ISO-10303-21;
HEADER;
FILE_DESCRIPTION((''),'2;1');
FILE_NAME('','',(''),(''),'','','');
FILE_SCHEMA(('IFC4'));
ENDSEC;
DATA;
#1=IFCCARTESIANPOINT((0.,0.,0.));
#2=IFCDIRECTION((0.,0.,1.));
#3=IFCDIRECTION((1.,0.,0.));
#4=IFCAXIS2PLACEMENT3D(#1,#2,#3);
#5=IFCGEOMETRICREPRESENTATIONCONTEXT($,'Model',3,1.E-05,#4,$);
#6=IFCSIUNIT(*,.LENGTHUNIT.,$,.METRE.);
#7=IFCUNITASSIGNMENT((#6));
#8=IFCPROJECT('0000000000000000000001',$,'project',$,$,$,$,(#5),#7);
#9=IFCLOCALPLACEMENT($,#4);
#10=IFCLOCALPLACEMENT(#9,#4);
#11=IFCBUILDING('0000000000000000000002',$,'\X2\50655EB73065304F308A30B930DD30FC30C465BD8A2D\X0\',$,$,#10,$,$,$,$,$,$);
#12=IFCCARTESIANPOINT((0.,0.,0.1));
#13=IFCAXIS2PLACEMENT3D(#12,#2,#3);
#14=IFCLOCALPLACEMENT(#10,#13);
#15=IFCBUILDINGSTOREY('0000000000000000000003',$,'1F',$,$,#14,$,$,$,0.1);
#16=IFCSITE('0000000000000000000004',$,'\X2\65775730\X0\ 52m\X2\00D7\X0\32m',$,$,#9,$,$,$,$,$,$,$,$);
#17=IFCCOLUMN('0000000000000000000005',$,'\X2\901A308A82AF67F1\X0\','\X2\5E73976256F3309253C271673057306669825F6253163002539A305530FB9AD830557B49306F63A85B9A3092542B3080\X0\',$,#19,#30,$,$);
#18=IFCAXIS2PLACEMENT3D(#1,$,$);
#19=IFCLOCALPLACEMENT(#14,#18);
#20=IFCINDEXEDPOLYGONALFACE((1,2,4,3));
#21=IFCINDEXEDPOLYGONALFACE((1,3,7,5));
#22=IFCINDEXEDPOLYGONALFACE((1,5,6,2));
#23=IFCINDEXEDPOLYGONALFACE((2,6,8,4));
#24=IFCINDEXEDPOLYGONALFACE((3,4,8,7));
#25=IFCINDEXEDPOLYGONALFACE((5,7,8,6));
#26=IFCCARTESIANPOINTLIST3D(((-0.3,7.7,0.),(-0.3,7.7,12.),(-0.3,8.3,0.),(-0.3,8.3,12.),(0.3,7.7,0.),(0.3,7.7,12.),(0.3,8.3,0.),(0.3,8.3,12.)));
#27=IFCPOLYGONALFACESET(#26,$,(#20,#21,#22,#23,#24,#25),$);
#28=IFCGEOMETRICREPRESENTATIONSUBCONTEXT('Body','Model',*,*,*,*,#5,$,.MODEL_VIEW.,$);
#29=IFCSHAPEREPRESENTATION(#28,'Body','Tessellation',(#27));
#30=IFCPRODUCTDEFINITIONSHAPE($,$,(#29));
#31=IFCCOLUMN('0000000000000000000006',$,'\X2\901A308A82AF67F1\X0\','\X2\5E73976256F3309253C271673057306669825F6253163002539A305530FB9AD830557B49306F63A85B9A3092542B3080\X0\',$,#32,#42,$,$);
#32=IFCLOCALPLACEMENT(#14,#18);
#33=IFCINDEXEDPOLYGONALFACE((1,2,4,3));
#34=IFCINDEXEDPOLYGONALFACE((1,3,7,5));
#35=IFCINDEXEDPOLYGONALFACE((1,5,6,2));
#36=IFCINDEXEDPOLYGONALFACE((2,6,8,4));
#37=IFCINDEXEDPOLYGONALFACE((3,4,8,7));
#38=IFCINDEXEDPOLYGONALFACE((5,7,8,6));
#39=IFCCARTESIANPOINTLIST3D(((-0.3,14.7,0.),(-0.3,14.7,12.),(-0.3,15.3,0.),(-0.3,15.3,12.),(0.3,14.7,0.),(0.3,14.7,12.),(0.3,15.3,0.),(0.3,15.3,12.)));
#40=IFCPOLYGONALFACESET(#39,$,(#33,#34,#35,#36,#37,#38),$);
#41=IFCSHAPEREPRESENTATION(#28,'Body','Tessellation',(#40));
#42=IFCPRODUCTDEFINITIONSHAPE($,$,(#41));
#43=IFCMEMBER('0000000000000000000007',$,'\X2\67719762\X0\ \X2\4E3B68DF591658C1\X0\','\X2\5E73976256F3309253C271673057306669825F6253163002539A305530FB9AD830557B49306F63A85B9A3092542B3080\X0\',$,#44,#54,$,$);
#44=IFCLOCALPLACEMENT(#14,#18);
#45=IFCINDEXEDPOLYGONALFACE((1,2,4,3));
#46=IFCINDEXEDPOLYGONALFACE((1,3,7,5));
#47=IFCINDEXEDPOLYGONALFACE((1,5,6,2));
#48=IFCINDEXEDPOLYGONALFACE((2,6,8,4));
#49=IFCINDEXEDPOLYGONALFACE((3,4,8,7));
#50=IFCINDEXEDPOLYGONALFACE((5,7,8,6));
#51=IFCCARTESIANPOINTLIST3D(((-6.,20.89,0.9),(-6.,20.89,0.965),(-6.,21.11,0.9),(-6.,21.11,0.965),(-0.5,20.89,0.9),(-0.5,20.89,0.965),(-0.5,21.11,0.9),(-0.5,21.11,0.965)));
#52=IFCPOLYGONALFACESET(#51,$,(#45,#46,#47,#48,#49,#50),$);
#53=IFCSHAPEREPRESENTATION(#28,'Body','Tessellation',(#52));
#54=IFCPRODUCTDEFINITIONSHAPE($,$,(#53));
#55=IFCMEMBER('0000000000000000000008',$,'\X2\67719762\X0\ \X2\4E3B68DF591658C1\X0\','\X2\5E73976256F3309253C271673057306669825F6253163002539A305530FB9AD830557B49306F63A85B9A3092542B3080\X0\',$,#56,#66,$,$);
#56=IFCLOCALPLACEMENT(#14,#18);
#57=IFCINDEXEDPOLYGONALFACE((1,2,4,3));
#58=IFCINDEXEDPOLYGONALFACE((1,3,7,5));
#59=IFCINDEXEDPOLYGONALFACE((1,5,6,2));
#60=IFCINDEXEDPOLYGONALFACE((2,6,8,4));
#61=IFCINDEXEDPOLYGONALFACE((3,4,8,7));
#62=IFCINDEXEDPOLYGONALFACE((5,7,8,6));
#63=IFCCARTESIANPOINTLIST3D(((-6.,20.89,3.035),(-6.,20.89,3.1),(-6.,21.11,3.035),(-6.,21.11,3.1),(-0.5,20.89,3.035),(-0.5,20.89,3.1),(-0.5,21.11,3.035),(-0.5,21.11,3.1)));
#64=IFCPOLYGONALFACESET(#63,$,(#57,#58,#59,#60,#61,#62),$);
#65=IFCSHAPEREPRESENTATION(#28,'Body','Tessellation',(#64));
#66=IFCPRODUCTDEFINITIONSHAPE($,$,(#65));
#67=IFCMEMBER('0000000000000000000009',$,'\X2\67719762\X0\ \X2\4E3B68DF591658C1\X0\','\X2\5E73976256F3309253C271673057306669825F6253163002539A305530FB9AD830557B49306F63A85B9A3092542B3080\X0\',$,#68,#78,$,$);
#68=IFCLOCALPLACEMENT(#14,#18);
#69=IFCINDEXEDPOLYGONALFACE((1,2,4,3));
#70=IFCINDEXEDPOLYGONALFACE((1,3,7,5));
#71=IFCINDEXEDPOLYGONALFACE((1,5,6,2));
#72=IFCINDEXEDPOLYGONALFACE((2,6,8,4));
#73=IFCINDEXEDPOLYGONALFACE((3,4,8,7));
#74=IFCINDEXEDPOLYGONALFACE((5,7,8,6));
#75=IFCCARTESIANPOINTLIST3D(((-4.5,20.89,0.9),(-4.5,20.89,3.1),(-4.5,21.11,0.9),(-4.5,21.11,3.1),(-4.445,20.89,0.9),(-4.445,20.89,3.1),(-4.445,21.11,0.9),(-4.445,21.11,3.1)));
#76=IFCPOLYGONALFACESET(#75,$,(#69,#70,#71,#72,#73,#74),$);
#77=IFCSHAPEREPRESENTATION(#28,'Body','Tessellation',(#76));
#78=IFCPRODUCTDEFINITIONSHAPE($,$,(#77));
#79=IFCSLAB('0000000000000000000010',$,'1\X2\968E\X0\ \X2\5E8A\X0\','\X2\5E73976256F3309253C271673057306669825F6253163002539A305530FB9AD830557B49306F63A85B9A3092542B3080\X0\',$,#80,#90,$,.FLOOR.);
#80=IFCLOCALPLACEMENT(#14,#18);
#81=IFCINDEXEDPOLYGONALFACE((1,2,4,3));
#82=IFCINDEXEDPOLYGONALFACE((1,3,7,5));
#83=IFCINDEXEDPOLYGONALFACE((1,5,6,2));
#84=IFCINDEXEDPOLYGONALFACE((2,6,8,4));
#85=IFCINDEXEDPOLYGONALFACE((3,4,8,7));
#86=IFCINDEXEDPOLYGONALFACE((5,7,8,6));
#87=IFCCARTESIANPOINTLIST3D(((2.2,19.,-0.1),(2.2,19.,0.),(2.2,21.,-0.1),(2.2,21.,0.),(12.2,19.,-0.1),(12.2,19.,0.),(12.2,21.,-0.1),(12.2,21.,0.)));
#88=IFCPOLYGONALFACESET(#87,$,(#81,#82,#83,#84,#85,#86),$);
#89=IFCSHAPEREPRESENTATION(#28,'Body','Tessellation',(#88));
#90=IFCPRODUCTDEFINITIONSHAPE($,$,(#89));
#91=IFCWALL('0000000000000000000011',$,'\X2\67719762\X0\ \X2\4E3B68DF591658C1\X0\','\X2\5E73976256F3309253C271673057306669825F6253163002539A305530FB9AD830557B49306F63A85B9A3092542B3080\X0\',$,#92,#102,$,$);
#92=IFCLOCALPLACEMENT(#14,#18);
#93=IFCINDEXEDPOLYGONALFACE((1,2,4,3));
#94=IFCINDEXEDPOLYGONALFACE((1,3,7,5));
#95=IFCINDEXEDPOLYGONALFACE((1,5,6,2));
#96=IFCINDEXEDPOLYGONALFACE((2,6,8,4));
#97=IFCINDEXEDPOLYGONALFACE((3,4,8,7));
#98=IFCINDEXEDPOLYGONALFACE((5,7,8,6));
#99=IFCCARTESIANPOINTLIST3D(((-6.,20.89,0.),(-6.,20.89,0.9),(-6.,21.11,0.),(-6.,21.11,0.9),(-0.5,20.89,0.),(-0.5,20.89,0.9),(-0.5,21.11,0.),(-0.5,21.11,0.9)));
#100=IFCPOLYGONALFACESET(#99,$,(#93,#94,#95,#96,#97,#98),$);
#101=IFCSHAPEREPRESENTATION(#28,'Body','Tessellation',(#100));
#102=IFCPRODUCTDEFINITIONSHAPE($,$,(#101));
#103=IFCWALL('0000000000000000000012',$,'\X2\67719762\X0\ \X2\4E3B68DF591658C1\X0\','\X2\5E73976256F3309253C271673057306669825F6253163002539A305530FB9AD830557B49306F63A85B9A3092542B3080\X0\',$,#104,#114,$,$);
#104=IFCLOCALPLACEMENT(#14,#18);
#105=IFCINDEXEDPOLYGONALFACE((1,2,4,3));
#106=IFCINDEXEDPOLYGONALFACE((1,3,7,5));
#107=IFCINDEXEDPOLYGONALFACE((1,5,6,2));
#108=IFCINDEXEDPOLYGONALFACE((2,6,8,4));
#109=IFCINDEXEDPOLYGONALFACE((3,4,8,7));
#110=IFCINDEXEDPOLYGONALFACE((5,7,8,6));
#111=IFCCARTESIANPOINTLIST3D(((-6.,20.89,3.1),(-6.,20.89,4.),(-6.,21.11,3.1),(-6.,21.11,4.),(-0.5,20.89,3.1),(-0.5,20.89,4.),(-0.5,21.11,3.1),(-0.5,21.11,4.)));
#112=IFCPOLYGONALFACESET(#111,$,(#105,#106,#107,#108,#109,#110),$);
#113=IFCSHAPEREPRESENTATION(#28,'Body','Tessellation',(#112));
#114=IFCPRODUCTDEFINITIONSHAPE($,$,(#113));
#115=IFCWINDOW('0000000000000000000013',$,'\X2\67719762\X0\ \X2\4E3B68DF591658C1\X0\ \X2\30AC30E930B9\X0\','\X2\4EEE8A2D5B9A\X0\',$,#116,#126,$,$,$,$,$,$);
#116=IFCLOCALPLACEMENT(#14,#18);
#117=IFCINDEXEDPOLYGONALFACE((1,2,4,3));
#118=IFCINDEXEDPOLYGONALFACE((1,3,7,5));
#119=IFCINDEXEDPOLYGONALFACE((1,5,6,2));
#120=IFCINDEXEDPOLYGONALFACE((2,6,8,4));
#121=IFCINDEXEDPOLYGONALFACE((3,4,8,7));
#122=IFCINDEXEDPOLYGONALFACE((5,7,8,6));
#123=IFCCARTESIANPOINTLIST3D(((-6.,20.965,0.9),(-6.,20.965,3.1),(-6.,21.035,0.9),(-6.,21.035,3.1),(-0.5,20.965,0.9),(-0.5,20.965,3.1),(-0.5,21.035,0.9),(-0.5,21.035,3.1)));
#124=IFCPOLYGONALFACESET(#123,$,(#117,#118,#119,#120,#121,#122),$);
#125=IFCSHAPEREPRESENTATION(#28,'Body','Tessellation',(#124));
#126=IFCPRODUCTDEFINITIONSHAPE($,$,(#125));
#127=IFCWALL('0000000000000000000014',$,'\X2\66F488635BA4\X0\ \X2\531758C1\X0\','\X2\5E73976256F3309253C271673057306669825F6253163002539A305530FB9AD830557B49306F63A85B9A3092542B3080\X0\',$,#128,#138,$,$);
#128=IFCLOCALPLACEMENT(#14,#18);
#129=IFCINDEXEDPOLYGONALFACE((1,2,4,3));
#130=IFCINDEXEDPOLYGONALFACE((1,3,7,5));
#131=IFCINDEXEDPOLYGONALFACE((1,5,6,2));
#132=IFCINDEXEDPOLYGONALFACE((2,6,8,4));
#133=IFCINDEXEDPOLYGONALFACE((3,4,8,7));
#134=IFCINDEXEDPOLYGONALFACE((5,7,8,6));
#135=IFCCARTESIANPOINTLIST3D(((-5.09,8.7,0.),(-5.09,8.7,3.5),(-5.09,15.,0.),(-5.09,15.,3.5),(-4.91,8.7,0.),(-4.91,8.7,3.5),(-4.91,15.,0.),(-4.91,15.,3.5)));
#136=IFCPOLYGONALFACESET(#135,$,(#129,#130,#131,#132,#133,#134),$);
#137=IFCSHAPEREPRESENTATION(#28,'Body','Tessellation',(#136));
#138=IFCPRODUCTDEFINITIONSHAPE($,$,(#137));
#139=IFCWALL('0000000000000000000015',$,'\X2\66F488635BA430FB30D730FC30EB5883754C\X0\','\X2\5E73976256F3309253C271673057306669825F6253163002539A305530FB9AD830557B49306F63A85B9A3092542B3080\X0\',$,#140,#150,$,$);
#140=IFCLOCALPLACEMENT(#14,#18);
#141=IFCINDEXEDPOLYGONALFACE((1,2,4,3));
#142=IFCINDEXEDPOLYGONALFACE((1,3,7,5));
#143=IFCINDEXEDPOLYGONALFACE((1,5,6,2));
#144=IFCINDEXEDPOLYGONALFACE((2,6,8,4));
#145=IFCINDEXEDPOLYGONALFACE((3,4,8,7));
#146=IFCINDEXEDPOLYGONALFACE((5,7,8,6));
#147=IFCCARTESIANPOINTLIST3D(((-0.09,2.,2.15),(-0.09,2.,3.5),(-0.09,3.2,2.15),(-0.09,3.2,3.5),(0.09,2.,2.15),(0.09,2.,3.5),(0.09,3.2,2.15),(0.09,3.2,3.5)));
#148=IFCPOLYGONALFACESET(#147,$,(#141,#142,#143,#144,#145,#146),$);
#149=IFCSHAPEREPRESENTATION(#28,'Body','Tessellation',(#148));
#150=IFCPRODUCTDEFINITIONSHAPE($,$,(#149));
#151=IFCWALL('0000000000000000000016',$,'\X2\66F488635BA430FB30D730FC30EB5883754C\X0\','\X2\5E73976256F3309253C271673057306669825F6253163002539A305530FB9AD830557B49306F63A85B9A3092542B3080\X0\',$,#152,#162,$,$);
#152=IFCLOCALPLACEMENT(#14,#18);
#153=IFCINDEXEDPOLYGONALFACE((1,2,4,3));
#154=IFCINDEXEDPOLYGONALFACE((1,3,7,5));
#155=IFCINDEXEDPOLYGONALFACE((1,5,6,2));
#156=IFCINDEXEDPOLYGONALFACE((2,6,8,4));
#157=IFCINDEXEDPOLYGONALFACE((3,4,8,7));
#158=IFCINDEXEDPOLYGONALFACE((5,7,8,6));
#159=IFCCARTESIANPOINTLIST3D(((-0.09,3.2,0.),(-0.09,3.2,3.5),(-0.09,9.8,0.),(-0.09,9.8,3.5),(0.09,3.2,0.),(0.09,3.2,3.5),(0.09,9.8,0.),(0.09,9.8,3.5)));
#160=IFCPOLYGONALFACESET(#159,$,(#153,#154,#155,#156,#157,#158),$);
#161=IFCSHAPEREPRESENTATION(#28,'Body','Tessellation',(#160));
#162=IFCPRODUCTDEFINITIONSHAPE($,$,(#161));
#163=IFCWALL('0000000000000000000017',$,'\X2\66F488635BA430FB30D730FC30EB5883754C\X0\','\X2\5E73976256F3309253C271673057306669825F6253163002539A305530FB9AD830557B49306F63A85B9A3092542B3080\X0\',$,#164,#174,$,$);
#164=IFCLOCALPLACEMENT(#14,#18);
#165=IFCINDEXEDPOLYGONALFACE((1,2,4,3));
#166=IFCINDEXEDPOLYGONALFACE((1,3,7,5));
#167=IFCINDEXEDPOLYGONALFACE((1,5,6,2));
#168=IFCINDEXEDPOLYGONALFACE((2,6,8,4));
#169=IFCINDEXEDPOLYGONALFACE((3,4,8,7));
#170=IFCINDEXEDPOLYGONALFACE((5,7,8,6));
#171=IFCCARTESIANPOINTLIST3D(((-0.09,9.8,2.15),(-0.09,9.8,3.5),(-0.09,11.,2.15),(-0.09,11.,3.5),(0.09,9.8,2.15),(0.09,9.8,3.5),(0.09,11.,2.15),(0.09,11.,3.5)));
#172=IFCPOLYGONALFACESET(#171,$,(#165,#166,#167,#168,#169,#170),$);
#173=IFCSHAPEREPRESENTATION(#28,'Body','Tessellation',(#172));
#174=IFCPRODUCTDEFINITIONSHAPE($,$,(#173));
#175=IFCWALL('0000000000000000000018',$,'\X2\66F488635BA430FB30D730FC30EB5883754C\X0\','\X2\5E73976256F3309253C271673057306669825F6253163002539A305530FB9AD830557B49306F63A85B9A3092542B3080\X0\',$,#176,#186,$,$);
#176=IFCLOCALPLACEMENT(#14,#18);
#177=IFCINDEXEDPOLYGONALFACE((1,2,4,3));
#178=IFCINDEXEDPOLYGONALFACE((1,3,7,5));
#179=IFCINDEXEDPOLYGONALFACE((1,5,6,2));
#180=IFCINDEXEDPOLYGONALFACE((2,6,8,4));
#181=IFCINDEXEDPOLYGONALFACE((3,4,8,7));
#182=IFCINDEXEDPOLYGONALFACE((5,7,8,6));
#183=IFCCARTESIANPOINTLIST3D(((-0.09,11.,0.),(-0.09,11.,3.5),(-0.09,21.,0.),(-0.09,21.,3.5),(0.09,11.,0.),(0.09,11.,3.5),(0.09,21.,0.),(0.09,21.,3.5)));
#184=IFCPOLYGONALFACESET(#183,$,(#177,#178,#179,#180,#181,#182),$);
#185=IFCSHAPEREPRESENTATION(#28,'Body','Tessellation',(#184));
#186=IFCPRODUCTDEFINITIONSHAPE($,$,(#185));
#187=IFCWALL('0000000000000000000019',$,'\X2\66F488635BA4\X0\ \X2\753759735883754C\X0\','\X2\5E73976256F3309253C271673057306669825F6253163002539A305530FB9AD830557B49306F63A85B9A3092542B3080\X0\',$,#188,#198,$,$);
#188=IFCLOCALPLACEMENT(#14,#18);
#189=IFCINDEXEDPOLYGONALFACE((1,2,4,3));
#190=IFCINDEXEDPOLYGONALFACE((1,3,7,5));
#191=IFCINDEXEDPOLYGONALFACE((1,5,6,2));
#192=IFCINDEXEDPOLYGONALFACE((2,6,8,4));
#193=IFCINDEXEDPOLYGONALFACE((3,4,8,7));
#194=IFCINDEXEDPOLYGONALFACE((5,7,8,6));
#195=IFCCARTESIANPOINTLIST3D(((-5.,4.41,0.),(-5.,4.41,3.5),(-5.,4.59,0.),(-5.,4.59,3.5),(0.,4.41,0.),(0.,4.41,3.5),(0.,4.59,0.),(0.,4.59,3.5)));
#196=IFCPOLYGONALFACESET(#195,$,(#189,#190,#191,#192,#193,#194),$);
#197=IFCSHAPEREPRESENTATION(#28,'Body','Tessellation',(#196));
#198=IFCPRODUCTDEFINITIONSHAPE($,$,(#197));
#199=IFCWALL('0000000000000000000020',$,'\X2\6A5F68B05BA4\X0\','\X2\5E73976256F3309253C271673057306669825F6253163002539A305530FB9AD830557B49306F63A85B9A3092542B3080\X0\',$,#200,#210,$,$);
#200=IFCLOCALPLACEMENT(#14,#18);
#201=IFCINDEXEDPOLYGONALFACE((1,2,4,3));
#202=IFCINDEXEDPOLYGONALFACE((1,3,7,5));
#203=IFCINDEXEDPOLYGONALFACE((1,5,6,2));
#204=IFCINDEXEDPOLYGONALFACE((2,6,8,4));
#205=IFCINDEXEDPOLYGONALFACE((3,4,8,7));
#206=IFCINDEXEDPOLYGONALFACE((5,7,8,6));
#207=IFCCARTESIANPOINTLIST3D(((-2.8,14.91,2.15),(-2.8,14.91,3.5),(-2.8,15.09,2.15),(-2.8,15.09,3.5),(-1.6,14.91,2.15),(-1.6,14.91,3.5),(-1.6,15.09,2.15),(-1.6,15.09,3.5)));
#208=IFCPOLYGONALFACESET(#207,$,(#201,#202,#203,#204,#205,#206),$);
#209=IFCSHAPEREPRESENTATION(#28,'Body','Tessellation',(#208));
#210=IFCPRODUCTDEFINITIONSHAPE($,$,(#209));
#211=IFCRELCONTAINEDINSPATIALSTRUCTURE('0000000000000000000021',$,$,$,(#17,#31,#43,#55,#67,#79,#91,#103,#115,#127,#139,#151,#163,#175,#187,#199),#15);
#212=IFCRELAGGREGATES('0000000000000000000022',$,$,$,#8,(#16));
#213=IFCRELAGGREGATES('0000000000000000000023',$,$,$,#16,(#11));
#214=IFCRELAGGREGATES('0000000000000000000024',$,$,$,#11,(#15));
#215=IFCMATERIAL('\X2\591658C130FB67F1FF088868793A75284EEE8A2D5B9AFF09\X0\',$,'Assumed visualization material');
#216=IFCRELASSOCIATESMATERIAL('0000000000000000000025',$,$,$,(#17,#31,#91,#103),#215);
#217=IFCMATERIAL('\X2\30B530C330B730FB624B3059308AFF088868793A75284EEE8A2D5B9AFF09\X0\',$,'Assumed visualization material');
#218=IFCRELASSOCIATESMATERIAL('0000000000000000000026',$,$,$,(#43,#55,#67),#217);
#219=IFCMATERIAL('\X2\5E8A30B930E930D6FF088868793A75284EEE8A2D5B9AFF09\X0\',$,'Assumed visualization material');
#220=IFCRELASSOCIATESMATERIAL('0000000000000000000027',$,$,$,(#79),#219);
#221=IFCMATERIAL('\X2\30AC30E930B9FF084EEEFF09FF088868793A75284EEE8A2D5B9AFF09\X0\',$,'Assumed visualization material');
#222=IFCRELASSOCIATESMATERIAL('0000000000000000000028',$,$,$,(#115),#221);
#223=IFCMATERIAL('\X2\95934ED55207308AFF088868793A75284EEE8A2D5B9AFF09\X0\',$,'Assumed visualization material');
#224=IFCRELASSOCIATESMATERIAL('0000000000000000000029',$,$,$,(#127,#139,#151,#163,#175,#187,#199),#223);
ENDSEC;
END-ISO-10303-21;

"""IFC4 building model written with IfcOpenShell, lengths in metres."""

from ifc_helpers import new_model, si_unit, frame, origin_with_axes, place, context, subcontext, project, spatial, rectangle, extrude, material, element, save


model = new_model("IFC4")

# Units and contexts
model_context = context("Model", 3, precision=1e-05, world=origin_with_axes())
body_context = subcontext(model_context, "Body", "Model", "MODEL_VIEW")
ifc_project = project(units=[si_unit("LENGTHUNIT", "METRE")], contexts=[model_context])

# Site, building, storey
site_placement = place(None, origin_with_axes())
site = spatial("IfcSite", under=ifc_project, at=site_placement, Name="敷地 52m×32m")
building_placement = place(site_placement, origin_with_axes())
building = spatial("IfcBuilding", under=site, at=building_placement, Name="健康づくりスポーツ施設")
storey_placement = place(building_placement, frame((0.0, 0.0, 0.1), z_axis=(0.0, 0.0, 1.0), x_axis=(1.0, 0.0, 0.0)))
storey = spatial("IfcBuildingStorey", under=building, at=storey_placement, Name="1F", Elevation=0.1)

# Columns
ifc_material_1 = material(Name="外壁・柱（表示用仮設定）", Category="Assumed visualization material")
column_1_placement = place(storey_placement, frame((0.0, 8.0, 0.0), z_axis=(0.0, 0.0, 1.0), x_axis=(1.0, 0.0, 0.0)))
element("IfcColumn", 1, at=column_1_placement, inside=storey, material=ifc_material_1, Name="通り芯柱", Description="平面図を参照して概形化。厚さ・高さ等は推定を含む", context=body_context, shape_type="SweptSolid", body=[
    extrude(rectangle(XDim=0.6, YDim=0.6), origin_with_axes(), (0.0, 0.0, 1.0), 12.0),
])
column_2_placement = place(storey_placement, frame((0.0, 15.0, 0.0), z_axis=(0.0, 0.0, 1.0), x_axis=(1.0, 0.0, 0.0)))
element("IfcColumn", 2, at=column_2_placement, inside=storey, material=ifc_material_1, Name="通り芯柱", Description="平面図を参照して概形化。厚さ・高さ等は推定を含む", context=body_context, shape_type="SweptSolid", body=[
    extrude(rectangle(XDim=0.6, YDim=0.6), origin_with_axes(), (0.0, 0.0, 1.0), 12.0),
])

# Members
ifc_material_2 = material(Name="サッシ・手すり（表示用仮設定）", Category="Assumed visualization material")
for number, where, z_axis, x_axis, name in (
    (3, (-3.25, 21.0, 0.9), (0.0, 0.0, 1.0), (1.0, 0.0, 0.0), "東面 主棟外壁"),
    (4, (-3.25, 21.0, 3.035), (0.0, 0.0, 1.0), (1.0, 0.0, 0.0), "東面 主棟外壁"),
):
    element("IfcMember", number, at=place(storey_placement, frame(where, z_axis=z_axis, x_axis=x_axis)), inside=storey, material=ifc_material_2, Name=name, Description="平面図を参照して概形化。厚さ・高さ等は推定を含む", context=body_context, shape_type="SweptSolid", body=[
        extrude(rectangle(XDim=5.5, YDim=0.22), origin_with_axes(), (0.0, 0.0, 1.0), 0.065),
    ])
member_placement = place(storey_placement, frame((-4.4725, 21.0, 0.9), z_axis=(0.0, 0.0, 1.0), x_axis=(1.0, 0.0, 0.0)))
element("IfcMember", 5, at=member_placement, inside=storey, material=ifc_material_2, Name="東面 主棟外壁", Description="平面図を参照して概形化。厚さ・高さ等は推定を含む", context=body_context, shape_type="SweptSolid", body=[
    extrude(rectangle(XDim=0.055, YDim=0.22), origin_with_axes(), (0.0, 0.0, 1.0), 2.2),
])

# Slab
ifc_material_3 = material(Name="床スラブ（表示用仮設定）", Category="Assumed visualization material")
slab_placement = place(storey_placement, frame((7.2, 20.0, -0.1), z_axis=(0.0, 0.0, 1.0), x_axis=(1.0, 0.0, 0.0)))
element("IfcSlab", 6, at=slab_placement, inside=storey, material=ifc_material_3, Name="1階 床", Description="平面図を参照して概形化。厚さ・高さ等は推定を含む", PredefinedType="FLOOR", context=body_context, shape_type="SweptSolid", body=[
    extrude(rectangle(XDim=10.0, YDim=2.0), origin_with_axes(), (0.0, 0.0, 1.0), 0.1),
])

# Walls
wall_1_placement = place(storey_placement, frame((-3.25, 21.0, 0.0), z_axis=(0.0, 0.0, 1.0), x_axis=(1.0, 0.0, 0.0)))
element("IfcWall", 7, at=wall_1_placement, inside=storey, material=ifc_material_1, Name="東面 主棟外壁", Description="平面図を参照して概形化。厚さ・高さ等は推定を含む", context=body_context, shape_type="SweptSolid", body=[
    extrude(rectangle(XDim=5.5, YDim=0.22), origin_with_axes(), (0.0, 0.0, 1.0), 0.9),
])
wall_2_placement = place(storey_placement, frame((-3.25, 21.0, 3.1), z_axis=(0.0, 0.0, 1.0), x_axis=(1.0, 0.0, 0.0)))
element("IfcWall", 8, at=wall_2_placement, inside=storey, material=ifc_material_1, Name="東面 主棟外壁", Description="平面図を参照して概形化。厚さ・高さ等は推定を含む", context=body_context, shape_type="SweptSolid", body=[
    extrude(rectangle(XDim=5.5, YDim=0.22), origin_with_axes(), (0.0, 0.0, 1.0), 0.9),
])

# Window
ifc_material_4 = material(Name="ガラス（仮）（表示用仮設定）", Category="Assumed visualization material")
window_placement = place(storey_placement, frame((-3.25, 21.0, 0.9), z_axis=(0.0, 0.0, 1.0), x_axis=(1.0, 0.0, 0.0)))
element("IfcWindow", 9, at=window_placement, inside=storey, material=ifc_material_4, Name="東面 主棟外壁 ガラス", Description="仮設定", context=body_context, shape_type="SweptSolid", body=[
    extrude(rectangle(XDim=5.5, YDim=0.07), origin_with_axes(), (0.0, 0.0, 1.0), 2.2),
])

# Walls
ifc_material_5 = material(Name="間仕切り（表示用仮設定）", Category="Assumed visualization material")
wall_3_placement = place(storey_placement, frame((-5.0, 11.85, 0.0), z_axis=(0.0, 0.0, 1.0), x_axis=(1.0, 0.0, 0.0)))
element("IfcWall", 10, at=wall_3_placement, inside=storey, material=ifc_material_5, Name="更衣室 北壁", Description="平面図を参照して概形化。厚さ・高さ等は推定を含む", context=body_context, shape_type="SweptSolid", body=[
    extrude(rectangle(XDim=0.18, YDim=6.3), origin_with_axes(), (0.0, 0.0, 1.0), 3.5),
])
wall_4_placement = place(storey_placement, frame((0.0, 2.6, 2.15), z_axis=(0.0, 0.0, 1.0), x_axis=(1.0, 0.0, 0.0)))
element("IfcWall", 11, at=wall_4_placement, inside=storey, material=ifc_material_5, Name="更衣室・プール境界", Description="平面図を参照して概形化。厚さ・高さ等は推定を含む", context=body_context, shape_type="SweptSolid", body=[
    extrude(rectangle(XDim=0.18, YDim=1.2), origin_with_axes(), (0.0, 0.0, 1.0), 1.35),
])
wall_5_placement = place(storey_placement, frame((0.0, 6.5, 0.0), z_axis=(0.0, 0.0, 1.0), x_axis=(1.0, 0.0, 0.0)))
element("IfcWall", 12, at=wall_5_placement, inside=storey, material=ifc_material_5, Name="更衣室・プール境界", Description="平面図を参照して概形化。厚さ・高さ等は推定を含む", context=body_context, shape_type="SweptSolid", body=[
    extrude(rectangle(XDim=0.18, YDim=6.6), origin_with_axes(), (0.0, 0.0, 1.0), 3.5),
])
wall_6_placement = place(storey_placement, frame((0.0, 10.4, 2.15), z_axis=(0.0, 0.0, 1.0), x_axis=(1.0, 0.0, 0.0)))
element("IfcWall", 13, at=wall_6_placement, inside=storey, material=ifc_material_5, Name="更衣室・プール境界", Description="平面図を参照して概形化。厚さ・高さ等は推定を含む", context=body_context, shape_type="SweptSolid", body=[
    extrude(rectangle(XDim=0.18, YDim=1.2), origin_with_axes(), (0.0, 0.0, 1.0), 1.35),
])
wall_7_placement = place(storey_placement, frame((0.0, 16.0, 0.0), z_axis=(0.0, 0.0, 1.0), x_axis=(1.0, 0.0, 0.0)))
element("IfcWall", 14, at=wall_7_placement, inside=storey, material=ifc_material_5, Name="更衣室・プール境界", Description="平面図を参照して概形化。厚さ・高さ等は推定を含む", context=body_context, shape_type="SweptSolid", body=[
    extrude(rectangle(XDim=0.18, YDim=10.0), origin_with_axes(), (0.0, 0.0, 1.0), 3.5),
])
wall_8_placement = place(storey_placement, frame((-2.5, 4.5, 0.0), z_axis=(0.0, 0.0, 1.0), x_axis=(1.0, 0.0, 0.0)))
element("IfcWall", 15, at=wall_8_placement, inside=storey, material=ifc_material_5, Name="更衣室 男女境界", Description="平面図を参照して概形化。厚さ・高さ等は推定を含む", context=body_context, shape_type="SweptSolid", body=[
    extrude(rectangle(XDim=5.0, YDim=0.18), origin_with_axes(), (0.0, 0.0, 1.0), 3.5),
])
wall_9_placement = place(storey_placement, frame((-2.2, 15.0, 2.15), z_axis=(0.0, 0.0, 1.0), x_axis=(1.0, 0.0, 0.0)))
element("IfcWall", 16, at=wall_9_placement, inside=storey, material=ifc_material_5, Name="機械室", Description="平面図を参照して概形化。厚さ・高さ等は推定を含む", context=body_context, shape_type="SweptSolid", body=[
    extrude(rectangle(XDim=1.2, YDim=0.18), origin_with_axes(), (0.0, 0.0, 1.0), 1.35),
])

save(model, "model.ifc")
